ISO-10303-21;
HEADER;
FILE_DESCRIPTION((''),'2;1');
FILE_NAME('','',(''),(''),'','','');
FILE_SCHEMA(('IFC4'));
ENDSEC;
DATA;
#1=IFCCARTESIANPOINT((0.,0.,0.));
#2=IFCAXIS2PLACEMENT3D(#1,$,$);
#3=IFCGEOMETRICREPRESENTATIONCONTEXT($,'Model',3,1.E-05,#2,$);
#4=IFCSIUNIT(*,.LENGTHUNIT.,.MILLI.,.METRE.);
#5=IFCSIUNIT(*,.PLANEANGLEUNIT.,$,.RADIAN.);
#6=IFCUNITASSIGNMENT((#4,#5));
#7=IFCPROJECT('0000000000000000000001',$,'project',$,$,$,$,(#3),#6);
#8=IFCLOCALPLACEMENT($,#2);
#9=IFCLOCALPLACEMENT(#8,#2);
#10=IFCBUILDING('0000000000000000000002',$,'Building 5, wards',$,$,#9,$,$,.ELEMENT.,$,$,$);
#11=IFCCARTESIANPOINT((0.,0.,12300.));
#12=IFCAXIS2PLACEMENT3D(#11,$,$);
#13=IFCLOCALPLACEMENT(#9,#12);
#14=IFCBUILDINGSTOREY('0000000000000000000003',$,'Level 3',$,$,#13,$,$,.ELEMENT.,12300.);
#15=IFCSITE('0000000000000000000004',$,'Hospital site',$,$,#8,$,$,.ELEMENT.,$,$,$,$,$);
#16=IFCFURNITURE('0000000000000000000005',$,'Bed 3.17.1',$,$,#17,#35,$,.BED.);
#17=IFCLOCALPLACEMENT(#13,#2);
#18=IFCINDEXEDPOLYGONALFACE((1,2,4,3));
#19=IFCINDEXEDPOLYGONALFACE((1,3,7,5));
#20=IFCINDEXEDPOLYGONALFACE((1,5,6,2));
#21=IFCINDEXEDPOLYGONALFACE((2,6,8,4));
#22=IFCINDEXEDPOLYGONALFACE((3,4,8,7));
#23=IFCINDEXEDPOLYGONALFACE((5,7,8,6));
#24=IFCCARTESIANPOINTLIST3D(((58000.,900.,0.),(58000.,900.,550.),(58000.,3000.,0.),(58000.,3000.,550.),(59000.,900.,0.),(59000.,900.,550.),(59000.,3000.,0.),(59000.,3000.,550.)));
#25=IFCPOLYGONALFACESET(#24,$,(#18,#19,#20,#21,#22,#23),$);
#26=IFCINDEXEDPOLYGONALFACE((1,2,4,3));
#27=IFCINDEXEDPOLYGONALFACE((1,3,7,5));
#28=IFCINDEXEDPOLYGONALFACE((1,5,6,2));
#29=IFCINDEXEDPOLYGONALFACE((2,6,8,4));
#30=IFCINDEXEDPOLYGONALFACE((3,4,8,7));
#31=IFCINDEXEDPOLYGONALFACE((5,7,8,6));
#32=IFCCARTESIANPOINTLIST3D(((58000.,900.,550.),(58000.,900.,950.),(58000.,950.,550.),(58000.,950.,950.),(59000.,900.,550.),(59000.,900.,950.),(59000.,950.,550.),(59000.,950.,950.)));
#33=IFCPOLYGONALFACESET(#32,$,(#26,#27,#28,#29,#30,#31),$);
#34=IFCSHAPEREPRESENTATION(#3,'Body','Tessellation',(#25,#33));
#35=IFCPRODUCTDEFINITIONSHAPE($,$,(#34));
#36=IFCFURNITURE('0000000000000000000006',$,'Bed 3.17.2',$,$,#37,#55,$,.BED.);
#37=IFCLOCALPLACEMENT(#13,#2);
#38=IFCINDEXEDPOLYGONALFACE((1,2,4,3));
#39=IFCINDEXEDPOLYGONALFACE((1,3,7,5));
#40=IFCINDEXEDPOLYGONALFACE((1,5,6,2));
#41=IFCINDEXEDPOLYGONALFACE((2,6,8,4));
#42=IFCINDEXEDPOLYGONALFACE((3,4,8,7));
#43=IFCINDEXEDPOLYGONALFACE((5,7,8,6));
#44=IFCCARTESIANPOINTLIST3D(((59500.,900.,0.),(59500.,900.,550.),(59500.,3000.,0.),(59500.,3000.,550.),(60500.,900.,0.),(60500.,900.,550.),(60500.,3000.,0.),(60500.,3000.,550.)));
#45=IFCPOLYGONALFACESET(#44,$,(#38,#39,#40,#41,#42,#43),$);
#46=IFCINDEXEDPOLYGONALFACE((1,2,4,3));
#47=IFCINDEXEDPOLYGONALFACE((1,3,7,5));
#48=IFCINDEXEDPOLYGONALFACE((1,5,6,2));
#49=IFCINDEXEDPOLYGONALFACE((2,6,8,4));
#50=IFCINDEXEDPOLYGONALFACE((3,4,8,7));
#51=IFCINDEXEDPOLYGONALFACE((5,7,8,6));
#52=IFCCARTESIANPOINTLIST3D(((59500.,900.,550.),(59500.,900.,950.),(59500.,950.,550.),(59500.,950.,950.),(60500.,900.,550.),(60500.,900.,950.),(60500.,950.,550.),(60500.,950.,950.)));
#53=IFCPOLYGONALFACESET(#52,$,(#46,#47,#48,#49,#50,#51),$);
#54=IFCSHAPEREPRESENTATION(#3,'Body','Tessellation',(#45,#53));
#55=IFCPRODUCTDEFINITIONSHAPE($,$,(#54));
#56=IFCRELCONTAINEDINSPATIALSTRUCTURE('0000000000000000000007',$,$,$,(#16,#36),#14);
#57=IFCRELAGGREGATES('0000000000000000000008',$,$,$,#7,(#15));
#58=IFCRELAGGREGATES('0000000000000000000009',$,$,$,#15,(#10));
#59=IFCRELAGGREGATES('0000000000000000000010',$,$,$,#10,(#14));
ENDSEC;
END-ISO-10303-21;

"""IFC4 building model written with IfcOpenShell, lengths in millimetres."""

from ifc_helpers import new_model, si_unit, frame, frame_2d, origin, place, context, project, spatial, rectangle, extrude, element, save


model = new_model("IFC4")

# Units and contexts
model_context = context("Model", 3, precision=1e-05, world=origin())
ifc_project = project(units=[si_unit("LENGTHUNIT", "METRE", prefix="MILLI"), si_unit("PLANEANGLEUNIT", "RADIAN")], contexts=[model_context])

# Site, building, storey
site_placement = place(None, origin())
site = spatial("IfcSite", under=ifc_project, at=site_placement, Name="Hospital site", CompositionType="ELEMENT")
building_placement = place(site_placement, origin())
building = spatial("IfcBuilding", under=site, at=building_placement, Name="Building 5, wards", CompositionType="ELEMENT")
storey_placement = place(building_placement, frame((0.0, 0.0, 12300.0)))
storey = spatial("IfcBuildingStorey", under=building, at=storey_placement, Name="Level 3", CompositionType="ELEMENT", Elevation=12300.0)

# Furniture
for number, where, name in (
    (1, (58000.0, 900.0, 0.0), "Bed 3.17.1"),
    (2, (59500.0, 900.0, 0.0), "Bed 3.17.2"),
):
    element("IfcFurniture", number, at=place(storey_placement, frame(where)), inside=storey, Name=name, PredefinedType="BED", context=model_context, shape_type="SweptSolid", body=[
        extrude(rectangle(XDim=1000.0, YDim=2100.0, at=frame_2d((500.0, 1050.0))), origin(), (0.0, 0.0, 1.0), 550.0),
        extrude(rectangle(XDim=1000.0, YDim=50.0, at=frame_2d((500.0, 25.0))), frame((0.0, 0.0, 550.0)), (0.0, 0.0, 1.0), 400.0),
    ])

save(model, "model.ifc")
